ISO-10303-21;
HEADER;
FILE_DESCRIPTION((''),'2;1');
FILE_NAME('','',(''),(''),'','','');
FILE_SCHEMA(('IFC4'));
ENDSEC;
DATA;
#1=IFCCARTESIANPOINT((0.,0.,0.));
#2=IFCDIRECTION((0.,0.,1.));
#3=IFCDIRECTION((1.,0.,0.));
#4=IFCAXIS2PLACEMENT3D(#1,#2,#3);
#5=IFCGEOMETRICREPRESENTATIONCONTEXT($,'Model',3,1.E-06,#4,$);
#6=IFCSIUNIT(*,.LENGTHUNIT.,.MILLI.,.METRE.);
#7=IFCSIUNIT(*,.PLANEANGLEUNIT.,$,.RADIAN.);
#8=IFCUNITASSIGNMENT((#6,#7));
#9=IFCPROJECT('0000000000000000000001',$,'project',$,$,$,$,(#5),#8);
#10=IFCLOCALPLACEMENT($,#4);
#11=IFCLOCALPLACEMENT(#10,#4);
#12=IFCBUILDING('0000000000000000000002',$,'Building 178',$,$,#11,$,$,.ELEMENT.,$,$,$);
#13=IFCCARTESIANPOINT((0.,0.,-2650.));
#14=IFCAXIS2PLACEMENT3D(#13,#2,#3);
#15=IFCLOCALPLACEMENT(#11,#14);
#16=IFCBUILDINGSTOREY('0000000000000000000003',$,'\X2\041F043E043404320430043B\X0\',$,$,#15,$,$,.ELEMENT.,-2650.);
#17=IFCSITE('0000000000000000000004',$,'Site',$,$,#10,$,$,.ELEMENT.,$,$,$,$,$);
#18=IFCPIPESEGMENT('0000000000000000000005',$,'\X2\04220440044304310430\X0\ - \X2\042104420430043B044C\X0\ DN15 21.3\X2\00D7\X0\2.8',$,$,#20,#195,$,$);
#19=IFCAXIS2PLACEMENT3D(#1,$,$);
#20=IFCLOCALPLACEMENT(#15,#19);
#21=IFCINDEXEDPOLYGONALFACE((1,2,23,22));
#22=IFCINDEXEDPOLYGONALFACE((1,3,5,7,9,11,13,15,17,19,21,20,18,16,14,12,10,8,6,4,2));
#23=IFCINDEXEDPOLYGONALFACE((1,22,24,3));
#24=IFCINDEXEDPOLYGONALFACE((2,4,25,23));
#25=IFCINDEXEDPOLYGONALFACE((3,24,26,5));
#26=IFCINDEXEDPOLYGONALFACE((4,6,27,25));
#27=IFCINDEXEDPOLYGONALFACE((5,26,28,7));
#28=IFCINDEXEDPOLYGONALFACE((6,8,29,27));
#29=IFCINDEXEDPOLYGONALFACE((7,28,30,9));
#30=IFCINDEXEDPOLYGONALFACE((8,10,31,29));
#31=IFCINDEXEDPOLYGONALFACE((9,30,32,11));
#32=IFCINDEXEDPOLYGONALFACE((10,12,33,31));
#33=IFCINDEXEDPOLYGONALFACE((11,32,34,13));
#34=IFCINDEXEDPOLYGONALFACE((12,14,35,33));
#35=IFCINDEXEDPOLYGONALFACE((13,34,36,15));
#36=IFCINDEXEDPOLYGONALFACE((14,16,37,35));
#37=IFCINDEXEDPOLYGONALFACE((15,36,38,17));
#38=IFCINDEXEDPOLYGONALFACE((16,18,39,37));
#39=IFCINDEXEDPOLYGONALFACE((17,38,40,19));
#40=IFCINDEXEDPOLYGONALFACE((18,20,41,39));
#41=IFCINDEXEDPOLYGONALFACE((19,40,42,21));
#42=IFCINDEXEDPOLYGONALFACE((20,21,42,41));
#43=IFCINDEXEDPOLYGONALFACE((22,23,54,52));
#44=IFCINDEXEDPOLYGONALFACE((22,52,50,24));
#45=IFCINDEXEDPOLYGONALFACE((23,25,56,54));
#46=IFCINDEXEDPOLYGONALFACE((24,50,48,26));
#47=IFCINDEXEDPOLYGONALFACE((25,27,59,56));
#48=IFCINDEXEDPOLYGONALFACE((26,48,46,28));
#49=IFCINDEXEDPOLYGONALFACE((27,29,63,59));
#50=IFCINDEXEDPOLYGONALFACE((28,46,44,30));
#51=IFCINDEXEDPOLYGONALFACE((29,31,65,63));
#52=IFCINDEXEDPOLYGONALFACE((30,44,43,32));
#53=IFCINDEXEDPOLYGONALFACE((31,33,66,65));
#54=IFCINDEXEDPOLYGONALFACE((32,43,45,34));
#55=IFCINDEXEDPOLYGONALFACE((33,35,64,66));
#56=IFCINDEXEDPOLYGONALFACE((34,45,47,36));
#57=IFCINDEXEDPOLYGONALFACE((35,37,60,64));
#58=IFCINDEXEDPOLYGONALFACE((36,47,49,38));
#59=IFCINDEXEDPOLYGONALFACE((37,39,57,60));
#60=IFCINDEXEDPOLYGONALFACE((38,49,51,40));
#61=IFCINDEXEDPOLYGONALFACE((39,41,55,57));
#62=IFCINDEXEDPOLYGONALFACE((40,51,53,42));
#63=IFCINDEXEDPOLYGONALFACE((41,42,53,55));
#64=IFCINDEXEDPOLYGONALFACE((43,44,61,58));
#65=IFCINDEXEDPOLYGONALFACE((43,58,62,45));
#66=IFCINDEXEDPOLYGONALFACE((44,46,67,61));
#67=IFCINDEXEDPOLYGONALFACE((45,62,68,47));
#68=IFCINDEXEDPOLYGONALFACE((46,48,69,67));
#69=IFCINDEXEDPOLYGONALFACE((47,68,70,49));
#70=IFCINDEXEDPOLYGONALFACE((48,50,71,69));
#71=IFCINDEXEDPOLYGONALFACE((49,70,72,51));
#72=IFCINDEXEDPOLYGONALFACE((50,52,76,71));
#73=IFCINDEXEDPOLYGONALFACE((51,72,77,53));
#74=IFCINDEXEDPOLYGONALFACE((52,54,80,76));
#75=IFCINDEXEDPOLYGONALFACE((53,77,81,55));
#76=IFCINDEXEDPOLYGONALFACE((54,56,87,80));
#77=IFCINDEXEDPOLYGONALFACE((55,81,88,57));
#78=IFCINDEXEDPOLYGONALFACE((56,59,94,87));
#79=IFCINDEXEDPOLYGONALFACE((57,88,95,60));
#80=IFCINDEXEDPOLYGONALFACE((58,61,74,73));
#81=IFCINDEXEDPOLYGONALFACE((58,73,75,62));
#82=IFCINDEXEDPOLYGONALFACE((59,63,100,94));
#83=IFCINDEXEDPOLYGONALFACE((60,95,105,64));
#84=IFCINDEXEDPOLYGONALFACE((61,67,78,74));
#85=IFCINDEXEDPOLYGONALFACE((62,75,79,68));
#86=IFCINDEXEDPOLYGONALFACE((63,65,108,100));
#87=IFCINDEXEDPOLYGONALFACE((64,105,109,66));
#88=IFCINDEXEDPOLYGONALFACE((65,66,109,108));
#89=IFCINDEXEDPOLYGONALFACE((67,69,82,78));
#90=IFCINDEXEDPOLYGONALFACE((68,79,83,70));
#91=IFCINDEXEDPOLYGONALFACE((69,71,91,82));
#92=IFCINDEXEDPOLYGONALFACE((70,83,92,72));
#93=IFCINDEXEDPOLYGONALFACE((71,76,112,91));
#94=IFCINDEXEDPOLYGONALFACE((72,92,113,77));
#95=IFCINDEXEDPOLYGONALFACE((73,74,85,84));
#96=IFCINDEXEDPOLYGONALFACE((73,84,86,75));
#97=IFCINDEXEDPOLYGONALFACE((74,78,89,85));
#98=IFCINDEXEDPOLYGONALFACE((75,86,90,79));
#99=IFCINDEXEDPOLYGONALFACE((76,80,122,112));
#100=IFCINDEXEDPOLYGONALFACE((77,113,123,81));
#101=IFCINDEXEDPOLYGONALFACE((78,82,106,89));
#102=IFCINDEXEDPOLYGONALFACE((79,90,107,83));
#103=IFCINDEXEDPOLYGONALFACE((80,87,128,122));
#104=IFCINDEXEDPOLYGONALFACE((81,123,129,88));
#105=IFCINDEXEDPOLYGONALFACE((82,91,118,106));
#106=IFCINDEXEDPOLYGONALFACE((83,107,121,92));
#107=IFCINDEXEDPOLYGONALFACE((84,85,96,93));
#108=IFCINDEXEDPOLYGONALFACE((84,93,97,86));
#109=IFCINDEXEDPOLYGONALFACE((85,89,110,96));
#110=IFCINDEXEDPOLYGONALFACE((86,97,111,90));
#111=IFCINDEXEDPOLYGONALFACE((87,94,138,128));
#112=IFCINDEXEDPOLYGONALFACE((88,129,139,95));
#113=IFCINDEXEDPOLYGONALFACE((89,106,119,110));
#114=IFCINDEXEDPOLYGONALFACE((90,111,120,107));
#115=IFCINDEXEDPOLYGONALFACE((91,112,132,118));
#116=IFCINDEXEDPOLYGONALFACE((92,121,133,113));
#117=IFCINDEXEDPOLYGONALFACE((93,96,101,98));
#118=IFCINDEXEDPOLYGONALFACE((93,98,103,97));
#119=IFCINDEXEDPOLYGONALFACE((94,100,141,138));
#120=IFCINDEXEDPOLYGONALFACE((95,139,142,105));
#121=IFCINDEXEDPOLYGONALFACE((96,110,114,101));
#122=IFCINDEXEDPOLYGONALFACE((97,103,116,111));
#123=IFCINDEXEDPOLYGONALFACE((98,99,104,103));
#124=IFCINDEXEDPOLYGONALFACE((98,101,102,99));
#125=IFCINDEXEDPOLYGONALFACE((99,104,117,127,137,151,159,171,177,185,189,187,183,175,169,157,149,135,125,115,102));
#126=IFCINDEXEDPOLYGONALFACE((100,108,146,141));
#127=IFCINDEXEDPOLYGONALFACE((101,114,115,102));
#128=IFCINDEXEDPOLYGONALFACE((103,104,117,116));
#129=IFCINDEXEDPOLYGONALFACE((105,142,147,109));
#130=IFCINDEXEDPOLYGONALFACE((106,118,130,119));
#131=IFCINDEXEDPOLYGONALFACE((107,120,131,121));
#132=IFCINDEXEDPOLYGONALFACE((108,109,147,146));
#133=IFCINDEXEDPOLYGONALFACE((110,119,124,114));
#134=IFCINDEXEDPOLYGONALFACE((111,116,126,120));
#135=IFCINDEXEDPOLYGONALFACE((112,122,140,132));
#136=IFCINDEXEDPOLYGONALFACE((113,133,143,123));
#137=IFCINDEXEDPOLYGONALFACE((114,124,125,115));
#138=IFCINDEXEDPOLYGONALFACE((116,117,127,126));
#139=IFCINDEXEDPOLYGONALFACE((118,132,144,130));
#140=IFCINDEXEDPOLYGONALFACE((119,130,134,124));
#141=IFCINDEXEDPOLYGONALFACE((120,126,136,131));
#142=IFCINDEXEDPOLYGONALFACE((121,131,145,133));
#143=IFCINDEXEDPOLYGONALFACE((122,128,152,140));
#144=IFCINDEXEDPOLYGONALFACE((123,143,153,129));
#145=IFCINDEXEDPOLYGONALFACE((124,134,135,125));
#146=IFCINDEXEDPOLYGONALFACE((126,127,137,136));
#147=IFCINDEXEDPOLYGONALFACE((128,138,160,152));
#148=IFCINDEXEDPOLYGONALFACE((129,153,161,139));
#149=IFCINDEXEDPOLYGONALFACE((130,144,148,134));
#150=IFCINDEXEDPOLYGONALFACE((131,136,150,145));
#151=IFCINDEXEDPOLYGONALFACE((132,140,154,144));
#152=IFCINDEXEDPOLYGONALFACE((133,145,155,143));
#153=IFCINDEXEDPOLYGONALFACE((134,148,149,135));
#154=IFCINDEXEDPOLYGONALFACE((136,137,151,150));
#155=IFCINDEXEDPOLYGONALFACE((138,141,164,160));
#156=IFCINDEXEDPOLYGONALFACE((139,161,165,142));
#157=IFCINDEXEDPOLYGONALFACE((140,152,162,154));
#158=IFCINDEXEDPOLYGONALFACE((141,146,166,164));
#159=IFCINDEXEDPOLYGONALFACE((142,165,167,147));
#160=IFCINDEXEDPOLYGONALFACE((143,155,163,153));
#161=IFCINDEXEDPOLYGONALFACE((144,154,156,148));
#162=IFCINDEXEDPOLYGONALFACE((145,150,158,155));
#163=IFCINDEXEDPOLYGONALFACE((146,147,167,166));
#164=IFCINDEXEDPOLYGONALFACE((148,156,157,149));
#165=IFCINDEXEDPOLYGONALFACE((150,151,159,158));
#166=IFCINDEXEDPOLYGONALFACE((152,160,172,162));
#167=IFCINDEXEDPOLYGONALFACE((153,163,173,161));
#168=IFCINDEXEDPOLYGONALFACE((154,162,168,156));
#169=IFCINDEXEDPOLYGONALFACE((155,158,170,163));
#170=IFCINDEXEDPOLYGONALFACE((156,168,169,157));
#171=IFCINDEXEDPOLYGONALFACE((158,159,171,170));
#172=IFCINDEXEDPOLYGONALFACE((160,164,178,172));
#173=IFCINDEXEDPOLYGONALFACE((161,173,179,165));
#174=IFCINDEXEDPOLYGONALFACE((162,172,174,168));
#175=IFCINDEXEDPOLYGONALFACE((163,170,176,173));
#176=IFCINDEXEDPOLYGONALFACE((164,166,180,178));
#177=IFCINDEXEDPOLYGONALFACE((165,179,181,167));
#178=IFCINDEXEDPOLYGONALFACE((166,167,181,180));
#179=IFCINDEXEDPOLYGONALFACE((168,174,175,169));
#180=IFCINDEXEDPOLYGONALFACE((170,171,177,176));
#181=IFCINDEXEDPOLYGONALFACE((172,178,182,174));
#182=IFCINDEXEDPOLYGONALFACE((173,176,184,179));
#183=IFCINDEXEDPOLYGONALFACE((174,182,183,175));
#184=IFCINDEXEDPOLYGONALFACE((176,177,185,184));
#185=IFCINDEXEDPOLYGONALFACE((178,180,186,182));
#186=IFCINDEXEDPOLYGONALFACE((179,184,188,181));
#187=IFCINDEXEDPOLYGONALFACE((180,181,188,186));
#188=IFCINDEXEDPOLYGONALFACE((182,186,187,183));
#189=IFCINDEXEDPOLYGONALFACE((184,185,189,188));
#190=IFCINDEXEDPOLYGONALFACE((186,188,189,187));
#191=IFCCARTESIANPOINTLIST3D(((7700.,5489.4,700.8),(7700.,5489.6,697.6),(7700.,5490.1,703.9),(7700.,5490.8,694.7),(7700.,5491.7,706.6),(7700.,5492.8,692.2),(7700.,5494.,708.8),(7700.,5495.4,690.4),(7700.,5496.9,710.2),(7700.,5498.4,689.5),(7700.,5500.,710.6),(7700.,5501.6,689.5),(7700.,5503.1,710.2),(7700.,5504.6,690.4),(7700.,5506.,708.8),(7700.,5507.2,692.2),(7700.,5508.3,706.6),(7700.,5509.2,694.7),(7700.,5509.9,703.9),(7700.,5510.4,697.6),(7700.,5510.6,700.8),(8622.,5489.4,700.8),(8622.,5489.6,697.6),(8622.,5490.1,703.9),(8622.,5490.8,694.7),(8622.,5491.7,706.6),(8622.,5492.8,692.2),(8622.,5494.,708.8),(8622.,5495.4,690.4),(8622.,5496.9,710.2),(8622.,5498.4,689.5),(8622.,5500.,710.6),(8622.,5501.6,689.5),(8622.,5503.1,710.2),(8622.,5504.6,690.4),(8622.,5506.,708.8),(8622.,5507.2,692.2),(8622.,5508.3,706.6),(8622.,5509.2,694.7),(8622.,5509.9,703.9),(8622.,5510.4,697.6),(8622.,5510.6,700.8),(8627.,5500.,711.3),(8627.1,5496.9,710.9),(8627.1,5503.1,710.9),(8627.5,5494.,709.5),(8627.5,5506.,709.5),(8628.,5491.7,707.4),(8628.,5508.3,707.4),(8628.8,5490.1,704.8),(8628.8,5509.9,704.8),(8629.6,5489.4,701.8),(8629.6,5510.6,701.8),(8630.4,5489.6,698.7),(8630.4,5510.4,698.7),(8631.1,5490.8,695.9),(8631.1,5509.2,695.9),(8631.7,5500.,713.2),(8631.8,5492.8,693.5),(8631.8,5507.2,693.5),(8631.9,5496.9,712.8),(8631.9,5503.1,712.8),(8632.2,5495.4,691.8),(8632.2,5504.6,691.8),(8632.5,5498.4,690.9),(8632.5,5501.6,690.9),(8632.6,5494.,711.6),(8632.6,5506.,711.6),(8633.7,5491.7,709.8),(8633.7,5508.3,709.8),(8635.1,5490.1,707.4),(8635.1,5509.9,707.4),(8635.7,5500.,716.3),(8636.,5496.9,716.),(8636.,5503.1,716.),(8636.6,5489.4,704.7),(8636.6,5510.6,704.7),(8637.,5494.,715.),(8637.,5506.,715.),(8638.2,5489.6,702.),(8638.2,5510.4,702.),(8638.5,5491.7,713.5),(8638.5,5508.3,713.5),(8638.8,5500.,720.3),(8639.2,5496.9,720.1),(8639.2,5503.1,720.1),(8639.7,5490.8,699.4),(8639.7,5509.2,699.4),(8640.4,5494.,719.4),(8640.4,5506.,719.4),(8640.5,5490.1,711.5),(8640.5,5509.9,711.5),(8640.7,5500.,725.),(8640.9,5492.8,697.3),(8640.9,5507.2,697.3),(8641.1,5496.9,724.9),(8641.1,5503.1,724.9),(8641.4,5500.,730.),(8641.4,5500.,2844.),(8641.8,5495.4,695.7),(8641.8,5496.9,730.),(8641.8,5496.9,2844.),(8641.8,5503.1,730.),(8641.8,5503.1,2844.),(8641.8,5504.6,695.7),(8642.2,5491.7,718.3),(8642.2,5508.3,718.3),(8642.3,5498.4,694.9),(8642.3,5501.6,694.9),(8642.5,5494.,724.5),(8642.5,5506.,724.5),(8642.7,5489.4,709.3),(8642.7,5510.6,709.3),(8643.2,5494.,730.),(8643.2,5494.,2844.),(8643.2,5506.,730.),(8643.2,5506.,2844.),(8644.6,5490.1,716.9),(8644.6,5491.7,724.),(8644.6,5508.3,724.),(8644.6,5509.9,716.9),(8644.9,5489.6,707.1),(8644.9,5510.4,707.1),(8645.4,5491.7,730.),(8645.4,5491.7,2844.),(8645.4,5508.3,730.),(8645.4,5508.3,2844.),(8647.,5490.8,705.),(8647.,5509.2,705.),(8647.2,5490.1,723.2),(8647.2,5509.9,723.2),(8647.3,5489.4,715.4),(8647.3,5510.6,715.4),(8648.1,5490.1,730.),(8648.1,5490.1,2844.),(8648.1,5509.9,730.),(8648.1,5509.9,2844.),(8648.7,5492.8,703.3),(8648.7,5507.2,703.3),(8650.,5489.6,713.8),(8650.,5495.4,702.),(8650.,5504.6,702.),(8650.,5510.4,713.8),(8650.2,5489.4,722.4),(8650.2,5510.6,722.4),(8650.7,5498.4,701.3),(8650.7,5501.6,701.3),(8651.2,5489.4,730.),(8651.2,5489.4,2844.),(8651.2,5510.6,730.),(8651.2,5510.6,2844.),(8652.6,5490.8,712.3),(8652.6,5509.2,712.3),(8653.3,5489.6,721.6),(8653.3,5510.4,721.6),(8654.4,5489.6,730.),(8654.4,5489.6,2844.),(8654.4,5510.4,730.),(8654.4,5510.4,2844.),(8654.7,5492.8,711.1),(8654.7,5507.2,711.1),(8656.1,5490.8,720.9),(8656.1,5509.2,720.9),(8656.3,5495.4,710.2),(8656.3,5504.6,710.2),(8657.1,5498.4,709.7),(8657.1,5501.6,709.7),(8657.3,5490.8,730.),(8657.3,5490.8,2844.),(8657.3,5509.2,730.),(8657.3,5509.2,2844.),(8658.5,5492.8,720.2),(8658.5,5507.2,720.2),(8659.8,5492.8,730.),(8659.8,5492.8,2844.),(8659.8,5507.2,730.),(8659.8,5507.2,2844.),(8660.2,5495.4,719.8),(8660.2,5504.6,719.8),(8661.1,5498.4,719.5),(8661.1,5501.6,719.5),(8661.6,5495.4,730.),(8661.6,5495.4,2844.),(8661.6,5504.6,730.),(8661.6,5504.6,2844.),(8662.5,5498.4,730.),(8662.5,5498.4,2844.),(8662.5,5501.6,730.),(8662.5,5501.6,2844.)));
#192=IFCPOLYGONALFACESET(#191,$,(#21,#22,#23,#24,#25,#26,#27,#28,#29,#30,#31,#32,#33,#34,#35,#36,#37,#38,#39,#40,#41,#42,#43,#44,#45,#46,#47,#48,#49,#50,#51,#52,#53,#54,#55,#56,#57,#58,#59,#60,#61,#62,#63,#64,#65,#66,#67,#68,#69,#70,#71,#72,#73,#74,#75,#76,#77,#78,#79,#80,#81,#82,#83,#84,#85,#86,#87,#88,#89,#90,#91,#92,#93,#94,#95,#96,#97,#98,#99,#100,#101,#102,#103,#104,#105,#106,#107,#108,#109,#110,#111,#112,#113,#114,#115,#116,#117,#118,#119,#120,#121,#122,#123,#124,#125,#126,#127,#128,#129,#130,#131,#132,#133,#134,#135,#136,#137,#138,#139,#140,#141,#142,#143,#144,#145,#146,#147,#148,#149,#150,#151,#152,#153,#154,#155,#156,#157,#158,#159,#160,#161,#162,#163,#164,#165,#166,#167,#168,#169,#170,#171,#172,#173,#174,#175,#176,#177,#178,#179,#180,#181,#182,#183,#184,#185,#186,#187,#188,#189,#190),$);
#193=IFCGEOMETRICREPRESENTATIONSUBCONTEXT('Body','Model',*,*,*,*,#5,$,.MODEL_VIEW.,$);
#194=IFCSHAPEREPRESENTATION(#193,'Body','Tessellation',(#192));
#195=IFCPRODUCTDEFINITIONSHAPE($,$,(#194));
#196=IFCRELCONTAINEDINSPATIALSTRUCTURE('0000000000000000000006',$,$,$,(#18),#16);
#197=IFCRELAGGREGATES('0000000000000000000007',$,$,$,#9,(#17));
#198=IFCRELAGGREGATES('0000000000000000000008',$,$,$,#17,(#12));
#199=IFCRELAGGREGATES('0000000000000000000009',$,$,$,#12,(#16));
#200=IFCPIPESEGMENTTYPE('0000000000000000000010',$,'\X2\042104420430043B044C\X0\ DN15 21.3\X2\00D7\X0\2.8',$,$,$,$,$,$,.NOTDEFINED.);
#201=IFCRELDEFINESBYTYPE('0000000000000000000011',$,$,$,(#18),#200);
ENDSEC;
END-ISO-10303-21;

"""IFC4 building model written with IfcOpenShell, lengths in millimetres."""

from ifc_helpers import new_model, entity, si_unit, frame, origin_with_axes, place, context, subcontext, project, spatial, source, transform, mapped, type_object, element, save


model = new_model("IFC4")

# Units and contexts
model_context = context("Model", 3, precision=1e-06, world=origin_with_axes())
body_context = subcontext(model_context, "Body", "Model", "MODEL_VIEW")
ifc_project = project(units=[si_unit("LENGTHUNIT", "METRE", prefix="MILLI"), si_unit("PLANEANGLEUNIT", "RADIAN")], contexts=[model_context])

# Site, building, storey
site_placement = place(None, origin_with_axes())
site = spatial("IfcSite", under=ifc_project, at=site_placement, Name="Site", CompositionType="ELEMENT")
building_placement = place(site_placement, origin_with_axes())
building = spatial("IfcBuilding", under=site, at=building_placement, Name="Building 178", CompositionType="ELEMENT")
storey_placement = place(building_placement, frame((0.0, 0.0, -2650.0), z_axis=(0.0, 0.0, 1.0), x_axis=(1.0, 0.0, 0.0)))
storey = spatial("IfcBuildingStorey", under=building, at=storey_placement, Name="Подвал", CompositionType="ELEMENT", Elevation=-2650.0)

# Pipe segment
pipe_segment_type_1 = type_object("IfcPipeSegmentType", Name="Сталь DN15 21.3×2.8", PredefinedType="NOTDEFINED")
shared_shape_1 = source(origin_with_axes(), body_context, "Body", "AdvancedSweptSolid", [
    entity("IfcSweptDiskSolid", entity("IfcIndexedPolyCurve", entity("IfcCartesianPointList3D", [[0.0, 0.0, 0.0], [0.0, 0.0, -2114.0], [-8.8, 0.0, -2135.2], [-30.0, 0.0, -2144.0], [-952.0, 0.0, -2144.0]]), [entity("IfcLineIndex", [1, 2]), entity("IfcArcIndex", [2, 3, 4]), entity("IfcLineIndex", [4, 5])]), 10.7),
])
pipe_segment_1_placement = place(storey_placement, frame((8652.0, 5500.0, 2844.0), z_axis=(0.0, 0.0, 1.0), x_axis=(1.0, 0.0, 0.0)))
element("IfcPipeSegment", 1, at=pipe_segment_1_placement, inside=storey, type_object=pipe_segment_type_1, Name="Труба - Сталь DN15 21.3×2.8", context=body_context, shape_type="MappedRepresentation", body=[
    mapped(shared_shape_1, transform((0.0, 0.0, 0.0), x_axis=(1.0, 0.0, 0.0), y_axis=(0.0, 1.0, 0.0), z_axis=(0.0, 0.0, 1.0), scale=1.0)),
])

save(model, "model.ifc")
